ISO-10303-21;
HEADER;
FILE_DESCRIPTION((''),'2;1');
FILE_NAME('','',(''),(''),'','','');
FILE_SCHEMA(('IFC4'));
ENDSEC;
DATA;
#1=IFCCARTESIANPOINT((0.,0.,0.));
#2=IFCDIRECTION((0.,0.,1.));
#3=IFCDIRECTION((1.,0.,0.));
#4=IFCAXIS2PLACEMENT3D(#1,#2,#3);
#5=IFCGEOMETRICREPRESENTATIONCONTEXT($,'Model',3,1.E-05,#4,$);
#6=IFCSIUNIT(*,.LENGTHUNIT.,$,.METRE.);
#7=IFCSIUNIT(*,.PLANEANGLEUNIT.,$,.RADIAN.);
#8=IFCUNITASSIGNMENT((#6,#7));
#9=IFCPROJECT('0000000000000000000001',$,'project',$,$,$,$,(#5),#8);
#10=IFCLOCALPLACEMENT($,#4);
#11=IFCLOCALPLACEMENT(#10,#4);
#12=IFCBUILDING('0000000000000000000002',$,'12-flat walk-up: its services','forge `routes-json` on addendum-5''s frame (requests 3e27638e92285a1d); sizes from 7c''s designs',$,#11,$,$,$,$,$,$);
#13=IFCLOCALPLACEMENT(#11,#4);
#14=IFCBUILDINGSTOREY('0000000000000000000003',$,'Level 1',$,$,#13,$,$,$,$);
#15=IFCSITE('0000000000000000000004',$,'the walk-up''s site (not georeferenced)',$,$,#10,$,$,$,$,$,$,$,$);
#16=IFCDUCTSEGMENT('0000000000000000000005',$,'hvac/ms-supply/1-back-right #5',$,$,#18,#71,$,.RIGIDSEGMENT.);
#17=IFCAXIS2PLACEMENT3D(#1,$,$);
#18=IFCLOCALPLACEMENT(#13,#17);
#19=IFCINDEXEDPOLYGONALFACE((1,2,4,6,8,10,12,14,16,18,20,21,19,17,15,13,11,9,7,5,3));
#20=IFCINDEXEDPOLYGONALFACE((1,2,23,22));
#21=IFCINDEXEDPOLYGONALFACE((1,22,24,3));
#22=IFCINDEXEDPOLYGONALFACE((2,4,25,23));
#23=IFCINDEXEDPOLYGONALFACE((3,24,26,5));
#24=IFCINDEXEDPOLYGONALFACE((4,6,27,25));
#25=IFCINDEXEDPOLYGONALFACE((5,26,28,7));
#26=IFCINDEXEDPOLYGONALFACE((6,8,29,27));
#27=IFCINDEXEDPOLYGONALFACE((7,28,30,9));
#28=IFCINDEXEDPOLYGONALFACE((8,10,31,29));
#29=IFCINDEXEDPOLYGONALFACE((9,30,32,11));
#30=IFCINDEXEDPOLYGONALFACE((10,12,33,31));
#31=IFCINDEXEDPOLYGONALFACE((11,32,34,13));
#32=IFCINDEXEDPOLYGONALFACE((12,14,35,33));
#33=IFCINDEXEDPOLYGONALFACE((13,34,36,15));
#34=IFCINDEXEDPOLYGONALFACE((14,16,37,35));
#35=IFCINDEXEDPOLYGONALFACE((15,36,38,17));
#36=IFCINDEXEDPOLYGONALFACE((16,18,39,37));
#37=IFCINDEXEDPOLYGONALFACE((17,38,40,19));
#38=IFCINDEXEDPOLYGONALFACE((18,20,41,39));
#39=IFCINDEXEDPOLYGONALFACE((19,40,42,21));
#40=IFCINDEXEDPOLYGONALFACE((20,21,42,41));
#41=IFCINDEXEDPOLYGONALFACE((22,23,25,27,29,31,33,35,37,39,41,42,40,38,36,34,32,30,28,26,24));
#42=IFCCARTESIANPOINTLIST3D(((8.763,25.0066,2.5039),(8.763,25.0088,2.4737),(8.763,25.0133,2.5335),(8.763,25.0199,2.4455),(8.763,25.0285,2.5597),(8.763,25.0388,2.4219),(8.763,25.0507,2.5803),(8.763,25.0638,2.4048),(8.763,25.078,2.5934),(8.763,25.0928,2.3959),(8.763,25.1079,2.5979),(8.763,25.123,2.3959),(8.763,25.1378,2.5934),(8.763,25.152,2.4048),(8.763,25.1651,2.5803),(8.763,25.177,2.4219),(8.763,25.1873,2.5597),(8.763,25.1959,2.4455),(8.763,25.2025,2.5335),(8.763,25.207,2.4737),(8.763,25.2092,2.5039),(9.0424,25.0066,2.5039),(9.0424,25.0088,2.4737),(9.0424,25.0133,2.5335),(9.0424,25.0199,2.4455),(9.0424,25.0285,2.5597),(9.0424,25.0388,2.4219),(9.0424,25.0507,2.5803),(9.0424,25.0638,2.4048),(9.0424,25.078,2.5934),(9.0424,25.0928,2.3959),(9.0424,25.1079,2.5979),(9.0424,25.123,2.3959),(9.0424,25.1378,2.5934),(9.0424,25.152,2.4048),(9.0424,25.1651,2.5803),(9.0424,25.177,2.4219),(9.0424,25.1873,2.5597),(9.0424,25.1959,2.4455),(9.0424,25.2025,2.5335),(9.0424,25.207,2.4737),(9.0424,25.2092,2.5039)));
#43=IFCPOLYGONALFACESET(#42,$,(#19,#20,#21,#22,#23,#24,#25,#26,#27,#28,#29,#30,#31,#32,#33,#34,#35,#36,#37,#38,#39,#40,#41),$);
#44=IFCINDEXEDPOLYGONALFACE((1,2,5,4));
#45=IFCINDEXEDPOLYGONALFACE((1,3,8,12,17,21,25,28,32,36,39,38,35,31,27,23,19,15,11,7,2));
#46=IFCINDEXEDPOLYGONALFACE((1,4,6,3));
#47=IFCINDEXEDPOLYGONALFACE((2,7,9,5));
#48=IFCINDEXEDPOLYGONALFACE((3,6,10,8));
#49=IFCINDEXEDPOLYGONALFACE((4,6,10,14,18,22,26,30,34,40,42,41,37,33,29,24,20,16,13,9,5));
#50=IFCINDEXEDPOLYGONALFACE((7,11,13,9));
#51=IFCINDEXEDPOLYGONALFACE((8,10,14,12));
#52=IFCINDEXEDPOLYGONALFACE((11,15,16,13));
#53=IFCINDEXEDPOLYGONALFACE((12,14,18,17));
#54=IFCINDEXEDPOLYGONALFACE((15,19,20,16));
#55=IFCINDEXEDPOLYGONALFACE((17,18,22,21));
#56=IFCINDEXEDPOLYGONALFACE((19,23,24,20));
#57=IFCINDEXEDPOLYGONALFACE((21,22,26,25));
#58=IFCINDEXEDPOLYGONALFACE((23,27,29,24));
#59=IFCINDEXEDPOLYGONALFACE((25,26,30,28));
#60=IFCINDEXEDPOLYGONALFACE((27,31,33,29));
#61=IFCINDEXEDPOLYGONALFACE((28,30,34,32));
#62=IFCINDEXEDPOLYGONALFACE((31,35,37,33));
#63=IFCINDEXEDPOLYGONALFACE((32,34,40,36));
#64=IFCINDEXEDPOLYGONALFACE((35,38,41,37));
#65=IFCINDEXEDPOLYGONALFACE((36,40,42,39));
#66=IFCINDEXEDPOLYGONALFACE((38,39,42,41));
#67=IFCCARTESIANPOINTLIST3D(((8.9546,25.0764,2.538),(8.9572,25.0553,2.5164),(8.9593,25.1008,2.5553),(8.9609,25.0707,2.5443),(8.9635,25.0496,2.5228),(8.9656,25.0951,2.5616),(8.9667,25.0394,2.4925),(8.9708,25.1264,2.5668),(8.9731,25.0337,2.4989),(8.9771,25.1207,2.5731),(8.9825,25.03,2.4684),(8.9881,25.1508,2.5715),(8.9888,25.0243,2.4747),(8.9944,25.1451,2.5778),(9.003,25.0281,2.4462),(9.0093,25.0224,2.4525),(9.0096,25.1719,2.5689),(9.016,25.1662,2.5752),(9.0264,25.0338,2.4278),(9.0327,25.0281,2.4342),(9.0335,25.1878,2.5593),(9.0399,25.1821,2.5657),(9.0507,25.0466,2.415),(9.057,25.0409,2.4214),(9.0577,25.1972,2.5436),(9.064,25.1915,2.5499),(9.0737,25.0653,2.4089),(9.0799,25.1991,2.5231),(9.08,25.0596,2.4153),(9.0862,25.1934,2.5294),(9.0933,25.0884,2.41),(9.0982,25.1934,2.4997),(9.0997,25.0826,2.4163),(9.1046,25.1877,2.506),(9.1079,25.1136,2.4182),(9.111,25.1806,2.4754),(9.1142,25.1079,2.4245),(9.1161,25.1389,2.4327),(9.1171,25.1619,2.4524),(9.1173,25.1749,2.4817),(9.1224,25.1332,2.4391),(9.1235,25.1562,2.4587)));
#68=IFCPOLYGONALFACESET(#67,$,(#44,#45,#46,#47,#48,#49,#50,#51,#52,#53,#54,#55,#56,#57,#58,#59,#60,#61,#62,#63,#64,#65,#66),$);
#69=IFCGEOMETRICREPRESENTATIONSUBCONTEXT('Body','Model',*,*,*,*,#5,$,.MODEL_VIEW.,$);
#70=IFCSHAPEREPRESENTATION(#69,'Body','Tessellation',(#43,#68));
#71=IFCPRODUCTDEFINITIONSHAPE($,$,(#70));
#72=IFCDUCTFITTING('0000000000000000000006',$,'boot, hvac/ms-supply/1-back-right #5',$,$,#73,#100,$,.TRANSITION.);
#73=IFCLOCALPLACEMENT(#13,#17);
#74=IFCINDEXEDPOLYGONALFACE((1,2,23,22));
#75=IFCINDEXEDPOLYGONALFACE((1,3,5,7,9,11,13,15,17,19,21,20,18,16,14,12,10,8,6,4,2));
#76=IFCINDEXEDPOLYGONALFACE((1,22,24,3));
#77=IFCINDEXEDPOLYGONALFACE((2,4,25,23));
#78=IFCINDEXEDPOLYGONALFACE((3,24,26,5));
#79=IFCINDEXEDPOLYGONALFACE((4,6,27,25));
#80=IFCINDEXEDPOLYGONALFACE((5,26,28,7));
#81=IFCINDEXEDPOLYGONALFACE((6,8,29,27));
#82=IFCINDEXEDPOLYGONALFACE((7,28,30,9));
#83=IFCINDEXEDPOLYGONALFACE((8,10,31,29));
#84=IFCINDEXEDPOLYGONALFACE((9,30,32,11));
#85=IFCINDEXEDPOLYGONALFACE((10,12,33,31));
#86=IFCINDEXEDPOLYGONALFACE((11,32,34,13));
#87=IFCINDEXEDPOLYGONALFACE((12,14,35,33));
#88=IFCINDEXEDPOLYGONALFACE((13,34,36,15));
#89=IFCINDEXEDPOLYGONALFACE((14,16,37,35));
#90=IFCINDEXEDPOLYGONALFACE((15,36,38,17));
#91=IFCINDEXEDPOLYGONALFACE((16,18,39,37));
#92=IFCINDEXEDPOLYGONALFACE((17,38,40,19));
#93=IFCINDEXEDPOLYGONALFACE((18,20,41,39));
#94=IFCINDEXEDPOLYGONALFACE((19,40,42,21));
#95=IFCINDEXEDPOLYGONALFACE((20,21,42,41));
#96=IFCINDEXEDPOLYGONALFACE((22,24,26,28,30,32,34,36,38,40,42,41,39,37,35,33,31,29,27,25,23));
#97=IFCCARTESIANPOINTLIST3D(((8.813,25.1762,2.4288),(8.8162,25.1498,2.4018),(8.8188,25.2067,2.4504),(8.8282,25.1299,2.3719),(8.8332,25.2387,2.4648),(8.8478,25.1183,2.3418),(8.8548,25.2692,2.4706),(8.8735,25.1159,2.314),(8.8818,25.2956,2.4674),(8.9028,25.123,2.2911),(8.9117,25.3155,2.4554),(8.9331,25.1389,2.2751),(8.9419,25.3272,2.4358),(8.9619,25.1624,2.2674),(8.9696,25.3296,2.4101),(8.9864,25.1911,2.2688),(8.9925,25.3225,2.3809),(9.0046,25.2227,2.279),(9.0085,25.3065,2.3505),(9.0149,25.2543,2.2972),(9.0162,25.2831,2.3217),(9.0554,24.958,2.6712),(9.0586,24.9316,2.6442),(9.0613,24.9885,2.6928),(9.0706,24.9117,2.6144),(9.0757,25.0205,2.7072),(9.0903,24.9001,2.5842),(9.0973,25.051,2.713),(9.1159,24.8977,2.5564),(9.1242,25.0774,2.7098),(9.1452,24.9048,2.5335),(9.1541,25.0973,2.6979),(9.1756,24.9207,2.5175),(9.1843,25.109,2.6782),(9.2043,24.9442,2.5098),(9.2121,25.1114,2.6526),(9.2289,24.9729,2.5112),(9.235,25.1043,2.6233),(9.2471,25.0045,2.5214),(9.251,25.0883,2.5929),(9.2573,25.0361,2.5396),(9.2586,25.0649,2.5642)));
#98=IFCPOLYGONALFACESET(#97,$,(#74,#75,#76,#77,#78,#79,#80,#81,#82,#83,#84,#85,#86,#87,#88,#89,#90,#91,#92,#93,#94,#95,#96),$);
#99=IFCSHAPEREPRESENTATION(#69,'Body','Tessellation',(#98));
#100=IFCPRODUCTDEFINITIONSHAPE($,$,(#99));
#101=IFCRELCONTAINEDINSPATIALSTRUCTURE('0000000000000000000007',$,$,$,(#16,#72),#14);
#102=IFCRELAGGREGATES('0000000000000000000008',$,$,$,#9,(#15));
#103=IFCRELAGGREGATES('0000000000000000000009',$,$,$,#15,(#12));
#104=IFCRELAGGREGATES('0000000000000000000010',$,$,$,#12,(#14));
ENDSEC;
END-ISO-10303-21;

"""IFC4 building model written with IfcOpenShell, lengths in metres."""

from ifc_helpers import new_model, entity, si_unit, frame, origin_with_axes, place, context, subcontext, project, spatial, element, save


model = new_model("IFC4")

# Units and contexts
model_context = context("Model", 3, precision=1e-05, world=origin_with_axes())
body_context = subcontext(model_context, "Body", "Model", "MODEL_VIEW")
ifc_project = project(units=[si_unit("LENGTHUNIT", "METRE"), si_unit("PLANEANGLEUNIT", "RADIAN")], contexts=[model_context])

# Site, building, storey
site_placement = place(None, origin_with_axes())
site = spatial("IfcSite", under=ifc_project, at=site_placement, Name="the walk-up's site (not georeferenced)")
building_placement = place(site_placement, origin_with_axes())
building = spatial("IfcBuilding", under=site, at=building_placement, Name="12-flat walk-up: its services", Description="forge `routes-json` on addendum-5's frame (requests 3e27638e92285a1d); sizes from 7c's designs")
storey_placement = place(building_placement, origin_with_axes())
storey = spatial("IfcBuildingStorey", under=building, at=storey_placement, Name="Level 1")

# Duct segment
duct_segment_1_placement = place(storey_placement, frame((8.763, 25.1079, 2.4963), z_axis=(0.0, 0.0, 1.0), x_axis=(1.0, 0.0, 0.0)))
element("IfcDuctSegment", 1, at=duct_segment_1_placement, inside=storey, Name="hvac/ms-supply/1-back-right #5", PredefinedType="RIGIDSEGMENT", context=body_context, shape_type="AdvancedSweptSolid", body=[
    entity("IfcSweptDiskSolid", entity("IfcPolyline", [entity("IfcCartesianPoint", [0.0, 0.0, 0.0]), entity("IfcCartesianPoint", [0.2794, 0.0, 0.0])]), 0.1016),
    entity("IfcSweptDiskSolid", entity("IfcPolyline", [entity("IfcCartesianPoint", [0.2794, 0.0, 0.0]), entity("IfcCartesianPoint", [0.273, 0.0057, -0.0063])]), 0.1016),
])

# Duct fitting
duct_fitting_1_placement = place(storey_placement, frame((9.1573, 25.0045, 2.6112), z_axis=(0.0, 0.0, 1.0), x_axis=(1.0, 0.0, 0.0)))
element("IfcDuctFitting", 2, at=duct_fitting_1_placement, inside=storey, Name="boot, hvac/ms-supply/1-back-right #5", PredefinedType="TRANSITION", context=body_context, shape_type="AdvancedSweptSolid", body=[
    entity("IfcSweptDiskSolid", entity("IfcPolyline", [entity("IfcCartesianPoint", [0.0, 0.0, 0.0]), entity("IfcCartesianPoint", [-0.2424, 0.2182, -0.2424])]), 0.127),
])

save(model, "model.ifc")
